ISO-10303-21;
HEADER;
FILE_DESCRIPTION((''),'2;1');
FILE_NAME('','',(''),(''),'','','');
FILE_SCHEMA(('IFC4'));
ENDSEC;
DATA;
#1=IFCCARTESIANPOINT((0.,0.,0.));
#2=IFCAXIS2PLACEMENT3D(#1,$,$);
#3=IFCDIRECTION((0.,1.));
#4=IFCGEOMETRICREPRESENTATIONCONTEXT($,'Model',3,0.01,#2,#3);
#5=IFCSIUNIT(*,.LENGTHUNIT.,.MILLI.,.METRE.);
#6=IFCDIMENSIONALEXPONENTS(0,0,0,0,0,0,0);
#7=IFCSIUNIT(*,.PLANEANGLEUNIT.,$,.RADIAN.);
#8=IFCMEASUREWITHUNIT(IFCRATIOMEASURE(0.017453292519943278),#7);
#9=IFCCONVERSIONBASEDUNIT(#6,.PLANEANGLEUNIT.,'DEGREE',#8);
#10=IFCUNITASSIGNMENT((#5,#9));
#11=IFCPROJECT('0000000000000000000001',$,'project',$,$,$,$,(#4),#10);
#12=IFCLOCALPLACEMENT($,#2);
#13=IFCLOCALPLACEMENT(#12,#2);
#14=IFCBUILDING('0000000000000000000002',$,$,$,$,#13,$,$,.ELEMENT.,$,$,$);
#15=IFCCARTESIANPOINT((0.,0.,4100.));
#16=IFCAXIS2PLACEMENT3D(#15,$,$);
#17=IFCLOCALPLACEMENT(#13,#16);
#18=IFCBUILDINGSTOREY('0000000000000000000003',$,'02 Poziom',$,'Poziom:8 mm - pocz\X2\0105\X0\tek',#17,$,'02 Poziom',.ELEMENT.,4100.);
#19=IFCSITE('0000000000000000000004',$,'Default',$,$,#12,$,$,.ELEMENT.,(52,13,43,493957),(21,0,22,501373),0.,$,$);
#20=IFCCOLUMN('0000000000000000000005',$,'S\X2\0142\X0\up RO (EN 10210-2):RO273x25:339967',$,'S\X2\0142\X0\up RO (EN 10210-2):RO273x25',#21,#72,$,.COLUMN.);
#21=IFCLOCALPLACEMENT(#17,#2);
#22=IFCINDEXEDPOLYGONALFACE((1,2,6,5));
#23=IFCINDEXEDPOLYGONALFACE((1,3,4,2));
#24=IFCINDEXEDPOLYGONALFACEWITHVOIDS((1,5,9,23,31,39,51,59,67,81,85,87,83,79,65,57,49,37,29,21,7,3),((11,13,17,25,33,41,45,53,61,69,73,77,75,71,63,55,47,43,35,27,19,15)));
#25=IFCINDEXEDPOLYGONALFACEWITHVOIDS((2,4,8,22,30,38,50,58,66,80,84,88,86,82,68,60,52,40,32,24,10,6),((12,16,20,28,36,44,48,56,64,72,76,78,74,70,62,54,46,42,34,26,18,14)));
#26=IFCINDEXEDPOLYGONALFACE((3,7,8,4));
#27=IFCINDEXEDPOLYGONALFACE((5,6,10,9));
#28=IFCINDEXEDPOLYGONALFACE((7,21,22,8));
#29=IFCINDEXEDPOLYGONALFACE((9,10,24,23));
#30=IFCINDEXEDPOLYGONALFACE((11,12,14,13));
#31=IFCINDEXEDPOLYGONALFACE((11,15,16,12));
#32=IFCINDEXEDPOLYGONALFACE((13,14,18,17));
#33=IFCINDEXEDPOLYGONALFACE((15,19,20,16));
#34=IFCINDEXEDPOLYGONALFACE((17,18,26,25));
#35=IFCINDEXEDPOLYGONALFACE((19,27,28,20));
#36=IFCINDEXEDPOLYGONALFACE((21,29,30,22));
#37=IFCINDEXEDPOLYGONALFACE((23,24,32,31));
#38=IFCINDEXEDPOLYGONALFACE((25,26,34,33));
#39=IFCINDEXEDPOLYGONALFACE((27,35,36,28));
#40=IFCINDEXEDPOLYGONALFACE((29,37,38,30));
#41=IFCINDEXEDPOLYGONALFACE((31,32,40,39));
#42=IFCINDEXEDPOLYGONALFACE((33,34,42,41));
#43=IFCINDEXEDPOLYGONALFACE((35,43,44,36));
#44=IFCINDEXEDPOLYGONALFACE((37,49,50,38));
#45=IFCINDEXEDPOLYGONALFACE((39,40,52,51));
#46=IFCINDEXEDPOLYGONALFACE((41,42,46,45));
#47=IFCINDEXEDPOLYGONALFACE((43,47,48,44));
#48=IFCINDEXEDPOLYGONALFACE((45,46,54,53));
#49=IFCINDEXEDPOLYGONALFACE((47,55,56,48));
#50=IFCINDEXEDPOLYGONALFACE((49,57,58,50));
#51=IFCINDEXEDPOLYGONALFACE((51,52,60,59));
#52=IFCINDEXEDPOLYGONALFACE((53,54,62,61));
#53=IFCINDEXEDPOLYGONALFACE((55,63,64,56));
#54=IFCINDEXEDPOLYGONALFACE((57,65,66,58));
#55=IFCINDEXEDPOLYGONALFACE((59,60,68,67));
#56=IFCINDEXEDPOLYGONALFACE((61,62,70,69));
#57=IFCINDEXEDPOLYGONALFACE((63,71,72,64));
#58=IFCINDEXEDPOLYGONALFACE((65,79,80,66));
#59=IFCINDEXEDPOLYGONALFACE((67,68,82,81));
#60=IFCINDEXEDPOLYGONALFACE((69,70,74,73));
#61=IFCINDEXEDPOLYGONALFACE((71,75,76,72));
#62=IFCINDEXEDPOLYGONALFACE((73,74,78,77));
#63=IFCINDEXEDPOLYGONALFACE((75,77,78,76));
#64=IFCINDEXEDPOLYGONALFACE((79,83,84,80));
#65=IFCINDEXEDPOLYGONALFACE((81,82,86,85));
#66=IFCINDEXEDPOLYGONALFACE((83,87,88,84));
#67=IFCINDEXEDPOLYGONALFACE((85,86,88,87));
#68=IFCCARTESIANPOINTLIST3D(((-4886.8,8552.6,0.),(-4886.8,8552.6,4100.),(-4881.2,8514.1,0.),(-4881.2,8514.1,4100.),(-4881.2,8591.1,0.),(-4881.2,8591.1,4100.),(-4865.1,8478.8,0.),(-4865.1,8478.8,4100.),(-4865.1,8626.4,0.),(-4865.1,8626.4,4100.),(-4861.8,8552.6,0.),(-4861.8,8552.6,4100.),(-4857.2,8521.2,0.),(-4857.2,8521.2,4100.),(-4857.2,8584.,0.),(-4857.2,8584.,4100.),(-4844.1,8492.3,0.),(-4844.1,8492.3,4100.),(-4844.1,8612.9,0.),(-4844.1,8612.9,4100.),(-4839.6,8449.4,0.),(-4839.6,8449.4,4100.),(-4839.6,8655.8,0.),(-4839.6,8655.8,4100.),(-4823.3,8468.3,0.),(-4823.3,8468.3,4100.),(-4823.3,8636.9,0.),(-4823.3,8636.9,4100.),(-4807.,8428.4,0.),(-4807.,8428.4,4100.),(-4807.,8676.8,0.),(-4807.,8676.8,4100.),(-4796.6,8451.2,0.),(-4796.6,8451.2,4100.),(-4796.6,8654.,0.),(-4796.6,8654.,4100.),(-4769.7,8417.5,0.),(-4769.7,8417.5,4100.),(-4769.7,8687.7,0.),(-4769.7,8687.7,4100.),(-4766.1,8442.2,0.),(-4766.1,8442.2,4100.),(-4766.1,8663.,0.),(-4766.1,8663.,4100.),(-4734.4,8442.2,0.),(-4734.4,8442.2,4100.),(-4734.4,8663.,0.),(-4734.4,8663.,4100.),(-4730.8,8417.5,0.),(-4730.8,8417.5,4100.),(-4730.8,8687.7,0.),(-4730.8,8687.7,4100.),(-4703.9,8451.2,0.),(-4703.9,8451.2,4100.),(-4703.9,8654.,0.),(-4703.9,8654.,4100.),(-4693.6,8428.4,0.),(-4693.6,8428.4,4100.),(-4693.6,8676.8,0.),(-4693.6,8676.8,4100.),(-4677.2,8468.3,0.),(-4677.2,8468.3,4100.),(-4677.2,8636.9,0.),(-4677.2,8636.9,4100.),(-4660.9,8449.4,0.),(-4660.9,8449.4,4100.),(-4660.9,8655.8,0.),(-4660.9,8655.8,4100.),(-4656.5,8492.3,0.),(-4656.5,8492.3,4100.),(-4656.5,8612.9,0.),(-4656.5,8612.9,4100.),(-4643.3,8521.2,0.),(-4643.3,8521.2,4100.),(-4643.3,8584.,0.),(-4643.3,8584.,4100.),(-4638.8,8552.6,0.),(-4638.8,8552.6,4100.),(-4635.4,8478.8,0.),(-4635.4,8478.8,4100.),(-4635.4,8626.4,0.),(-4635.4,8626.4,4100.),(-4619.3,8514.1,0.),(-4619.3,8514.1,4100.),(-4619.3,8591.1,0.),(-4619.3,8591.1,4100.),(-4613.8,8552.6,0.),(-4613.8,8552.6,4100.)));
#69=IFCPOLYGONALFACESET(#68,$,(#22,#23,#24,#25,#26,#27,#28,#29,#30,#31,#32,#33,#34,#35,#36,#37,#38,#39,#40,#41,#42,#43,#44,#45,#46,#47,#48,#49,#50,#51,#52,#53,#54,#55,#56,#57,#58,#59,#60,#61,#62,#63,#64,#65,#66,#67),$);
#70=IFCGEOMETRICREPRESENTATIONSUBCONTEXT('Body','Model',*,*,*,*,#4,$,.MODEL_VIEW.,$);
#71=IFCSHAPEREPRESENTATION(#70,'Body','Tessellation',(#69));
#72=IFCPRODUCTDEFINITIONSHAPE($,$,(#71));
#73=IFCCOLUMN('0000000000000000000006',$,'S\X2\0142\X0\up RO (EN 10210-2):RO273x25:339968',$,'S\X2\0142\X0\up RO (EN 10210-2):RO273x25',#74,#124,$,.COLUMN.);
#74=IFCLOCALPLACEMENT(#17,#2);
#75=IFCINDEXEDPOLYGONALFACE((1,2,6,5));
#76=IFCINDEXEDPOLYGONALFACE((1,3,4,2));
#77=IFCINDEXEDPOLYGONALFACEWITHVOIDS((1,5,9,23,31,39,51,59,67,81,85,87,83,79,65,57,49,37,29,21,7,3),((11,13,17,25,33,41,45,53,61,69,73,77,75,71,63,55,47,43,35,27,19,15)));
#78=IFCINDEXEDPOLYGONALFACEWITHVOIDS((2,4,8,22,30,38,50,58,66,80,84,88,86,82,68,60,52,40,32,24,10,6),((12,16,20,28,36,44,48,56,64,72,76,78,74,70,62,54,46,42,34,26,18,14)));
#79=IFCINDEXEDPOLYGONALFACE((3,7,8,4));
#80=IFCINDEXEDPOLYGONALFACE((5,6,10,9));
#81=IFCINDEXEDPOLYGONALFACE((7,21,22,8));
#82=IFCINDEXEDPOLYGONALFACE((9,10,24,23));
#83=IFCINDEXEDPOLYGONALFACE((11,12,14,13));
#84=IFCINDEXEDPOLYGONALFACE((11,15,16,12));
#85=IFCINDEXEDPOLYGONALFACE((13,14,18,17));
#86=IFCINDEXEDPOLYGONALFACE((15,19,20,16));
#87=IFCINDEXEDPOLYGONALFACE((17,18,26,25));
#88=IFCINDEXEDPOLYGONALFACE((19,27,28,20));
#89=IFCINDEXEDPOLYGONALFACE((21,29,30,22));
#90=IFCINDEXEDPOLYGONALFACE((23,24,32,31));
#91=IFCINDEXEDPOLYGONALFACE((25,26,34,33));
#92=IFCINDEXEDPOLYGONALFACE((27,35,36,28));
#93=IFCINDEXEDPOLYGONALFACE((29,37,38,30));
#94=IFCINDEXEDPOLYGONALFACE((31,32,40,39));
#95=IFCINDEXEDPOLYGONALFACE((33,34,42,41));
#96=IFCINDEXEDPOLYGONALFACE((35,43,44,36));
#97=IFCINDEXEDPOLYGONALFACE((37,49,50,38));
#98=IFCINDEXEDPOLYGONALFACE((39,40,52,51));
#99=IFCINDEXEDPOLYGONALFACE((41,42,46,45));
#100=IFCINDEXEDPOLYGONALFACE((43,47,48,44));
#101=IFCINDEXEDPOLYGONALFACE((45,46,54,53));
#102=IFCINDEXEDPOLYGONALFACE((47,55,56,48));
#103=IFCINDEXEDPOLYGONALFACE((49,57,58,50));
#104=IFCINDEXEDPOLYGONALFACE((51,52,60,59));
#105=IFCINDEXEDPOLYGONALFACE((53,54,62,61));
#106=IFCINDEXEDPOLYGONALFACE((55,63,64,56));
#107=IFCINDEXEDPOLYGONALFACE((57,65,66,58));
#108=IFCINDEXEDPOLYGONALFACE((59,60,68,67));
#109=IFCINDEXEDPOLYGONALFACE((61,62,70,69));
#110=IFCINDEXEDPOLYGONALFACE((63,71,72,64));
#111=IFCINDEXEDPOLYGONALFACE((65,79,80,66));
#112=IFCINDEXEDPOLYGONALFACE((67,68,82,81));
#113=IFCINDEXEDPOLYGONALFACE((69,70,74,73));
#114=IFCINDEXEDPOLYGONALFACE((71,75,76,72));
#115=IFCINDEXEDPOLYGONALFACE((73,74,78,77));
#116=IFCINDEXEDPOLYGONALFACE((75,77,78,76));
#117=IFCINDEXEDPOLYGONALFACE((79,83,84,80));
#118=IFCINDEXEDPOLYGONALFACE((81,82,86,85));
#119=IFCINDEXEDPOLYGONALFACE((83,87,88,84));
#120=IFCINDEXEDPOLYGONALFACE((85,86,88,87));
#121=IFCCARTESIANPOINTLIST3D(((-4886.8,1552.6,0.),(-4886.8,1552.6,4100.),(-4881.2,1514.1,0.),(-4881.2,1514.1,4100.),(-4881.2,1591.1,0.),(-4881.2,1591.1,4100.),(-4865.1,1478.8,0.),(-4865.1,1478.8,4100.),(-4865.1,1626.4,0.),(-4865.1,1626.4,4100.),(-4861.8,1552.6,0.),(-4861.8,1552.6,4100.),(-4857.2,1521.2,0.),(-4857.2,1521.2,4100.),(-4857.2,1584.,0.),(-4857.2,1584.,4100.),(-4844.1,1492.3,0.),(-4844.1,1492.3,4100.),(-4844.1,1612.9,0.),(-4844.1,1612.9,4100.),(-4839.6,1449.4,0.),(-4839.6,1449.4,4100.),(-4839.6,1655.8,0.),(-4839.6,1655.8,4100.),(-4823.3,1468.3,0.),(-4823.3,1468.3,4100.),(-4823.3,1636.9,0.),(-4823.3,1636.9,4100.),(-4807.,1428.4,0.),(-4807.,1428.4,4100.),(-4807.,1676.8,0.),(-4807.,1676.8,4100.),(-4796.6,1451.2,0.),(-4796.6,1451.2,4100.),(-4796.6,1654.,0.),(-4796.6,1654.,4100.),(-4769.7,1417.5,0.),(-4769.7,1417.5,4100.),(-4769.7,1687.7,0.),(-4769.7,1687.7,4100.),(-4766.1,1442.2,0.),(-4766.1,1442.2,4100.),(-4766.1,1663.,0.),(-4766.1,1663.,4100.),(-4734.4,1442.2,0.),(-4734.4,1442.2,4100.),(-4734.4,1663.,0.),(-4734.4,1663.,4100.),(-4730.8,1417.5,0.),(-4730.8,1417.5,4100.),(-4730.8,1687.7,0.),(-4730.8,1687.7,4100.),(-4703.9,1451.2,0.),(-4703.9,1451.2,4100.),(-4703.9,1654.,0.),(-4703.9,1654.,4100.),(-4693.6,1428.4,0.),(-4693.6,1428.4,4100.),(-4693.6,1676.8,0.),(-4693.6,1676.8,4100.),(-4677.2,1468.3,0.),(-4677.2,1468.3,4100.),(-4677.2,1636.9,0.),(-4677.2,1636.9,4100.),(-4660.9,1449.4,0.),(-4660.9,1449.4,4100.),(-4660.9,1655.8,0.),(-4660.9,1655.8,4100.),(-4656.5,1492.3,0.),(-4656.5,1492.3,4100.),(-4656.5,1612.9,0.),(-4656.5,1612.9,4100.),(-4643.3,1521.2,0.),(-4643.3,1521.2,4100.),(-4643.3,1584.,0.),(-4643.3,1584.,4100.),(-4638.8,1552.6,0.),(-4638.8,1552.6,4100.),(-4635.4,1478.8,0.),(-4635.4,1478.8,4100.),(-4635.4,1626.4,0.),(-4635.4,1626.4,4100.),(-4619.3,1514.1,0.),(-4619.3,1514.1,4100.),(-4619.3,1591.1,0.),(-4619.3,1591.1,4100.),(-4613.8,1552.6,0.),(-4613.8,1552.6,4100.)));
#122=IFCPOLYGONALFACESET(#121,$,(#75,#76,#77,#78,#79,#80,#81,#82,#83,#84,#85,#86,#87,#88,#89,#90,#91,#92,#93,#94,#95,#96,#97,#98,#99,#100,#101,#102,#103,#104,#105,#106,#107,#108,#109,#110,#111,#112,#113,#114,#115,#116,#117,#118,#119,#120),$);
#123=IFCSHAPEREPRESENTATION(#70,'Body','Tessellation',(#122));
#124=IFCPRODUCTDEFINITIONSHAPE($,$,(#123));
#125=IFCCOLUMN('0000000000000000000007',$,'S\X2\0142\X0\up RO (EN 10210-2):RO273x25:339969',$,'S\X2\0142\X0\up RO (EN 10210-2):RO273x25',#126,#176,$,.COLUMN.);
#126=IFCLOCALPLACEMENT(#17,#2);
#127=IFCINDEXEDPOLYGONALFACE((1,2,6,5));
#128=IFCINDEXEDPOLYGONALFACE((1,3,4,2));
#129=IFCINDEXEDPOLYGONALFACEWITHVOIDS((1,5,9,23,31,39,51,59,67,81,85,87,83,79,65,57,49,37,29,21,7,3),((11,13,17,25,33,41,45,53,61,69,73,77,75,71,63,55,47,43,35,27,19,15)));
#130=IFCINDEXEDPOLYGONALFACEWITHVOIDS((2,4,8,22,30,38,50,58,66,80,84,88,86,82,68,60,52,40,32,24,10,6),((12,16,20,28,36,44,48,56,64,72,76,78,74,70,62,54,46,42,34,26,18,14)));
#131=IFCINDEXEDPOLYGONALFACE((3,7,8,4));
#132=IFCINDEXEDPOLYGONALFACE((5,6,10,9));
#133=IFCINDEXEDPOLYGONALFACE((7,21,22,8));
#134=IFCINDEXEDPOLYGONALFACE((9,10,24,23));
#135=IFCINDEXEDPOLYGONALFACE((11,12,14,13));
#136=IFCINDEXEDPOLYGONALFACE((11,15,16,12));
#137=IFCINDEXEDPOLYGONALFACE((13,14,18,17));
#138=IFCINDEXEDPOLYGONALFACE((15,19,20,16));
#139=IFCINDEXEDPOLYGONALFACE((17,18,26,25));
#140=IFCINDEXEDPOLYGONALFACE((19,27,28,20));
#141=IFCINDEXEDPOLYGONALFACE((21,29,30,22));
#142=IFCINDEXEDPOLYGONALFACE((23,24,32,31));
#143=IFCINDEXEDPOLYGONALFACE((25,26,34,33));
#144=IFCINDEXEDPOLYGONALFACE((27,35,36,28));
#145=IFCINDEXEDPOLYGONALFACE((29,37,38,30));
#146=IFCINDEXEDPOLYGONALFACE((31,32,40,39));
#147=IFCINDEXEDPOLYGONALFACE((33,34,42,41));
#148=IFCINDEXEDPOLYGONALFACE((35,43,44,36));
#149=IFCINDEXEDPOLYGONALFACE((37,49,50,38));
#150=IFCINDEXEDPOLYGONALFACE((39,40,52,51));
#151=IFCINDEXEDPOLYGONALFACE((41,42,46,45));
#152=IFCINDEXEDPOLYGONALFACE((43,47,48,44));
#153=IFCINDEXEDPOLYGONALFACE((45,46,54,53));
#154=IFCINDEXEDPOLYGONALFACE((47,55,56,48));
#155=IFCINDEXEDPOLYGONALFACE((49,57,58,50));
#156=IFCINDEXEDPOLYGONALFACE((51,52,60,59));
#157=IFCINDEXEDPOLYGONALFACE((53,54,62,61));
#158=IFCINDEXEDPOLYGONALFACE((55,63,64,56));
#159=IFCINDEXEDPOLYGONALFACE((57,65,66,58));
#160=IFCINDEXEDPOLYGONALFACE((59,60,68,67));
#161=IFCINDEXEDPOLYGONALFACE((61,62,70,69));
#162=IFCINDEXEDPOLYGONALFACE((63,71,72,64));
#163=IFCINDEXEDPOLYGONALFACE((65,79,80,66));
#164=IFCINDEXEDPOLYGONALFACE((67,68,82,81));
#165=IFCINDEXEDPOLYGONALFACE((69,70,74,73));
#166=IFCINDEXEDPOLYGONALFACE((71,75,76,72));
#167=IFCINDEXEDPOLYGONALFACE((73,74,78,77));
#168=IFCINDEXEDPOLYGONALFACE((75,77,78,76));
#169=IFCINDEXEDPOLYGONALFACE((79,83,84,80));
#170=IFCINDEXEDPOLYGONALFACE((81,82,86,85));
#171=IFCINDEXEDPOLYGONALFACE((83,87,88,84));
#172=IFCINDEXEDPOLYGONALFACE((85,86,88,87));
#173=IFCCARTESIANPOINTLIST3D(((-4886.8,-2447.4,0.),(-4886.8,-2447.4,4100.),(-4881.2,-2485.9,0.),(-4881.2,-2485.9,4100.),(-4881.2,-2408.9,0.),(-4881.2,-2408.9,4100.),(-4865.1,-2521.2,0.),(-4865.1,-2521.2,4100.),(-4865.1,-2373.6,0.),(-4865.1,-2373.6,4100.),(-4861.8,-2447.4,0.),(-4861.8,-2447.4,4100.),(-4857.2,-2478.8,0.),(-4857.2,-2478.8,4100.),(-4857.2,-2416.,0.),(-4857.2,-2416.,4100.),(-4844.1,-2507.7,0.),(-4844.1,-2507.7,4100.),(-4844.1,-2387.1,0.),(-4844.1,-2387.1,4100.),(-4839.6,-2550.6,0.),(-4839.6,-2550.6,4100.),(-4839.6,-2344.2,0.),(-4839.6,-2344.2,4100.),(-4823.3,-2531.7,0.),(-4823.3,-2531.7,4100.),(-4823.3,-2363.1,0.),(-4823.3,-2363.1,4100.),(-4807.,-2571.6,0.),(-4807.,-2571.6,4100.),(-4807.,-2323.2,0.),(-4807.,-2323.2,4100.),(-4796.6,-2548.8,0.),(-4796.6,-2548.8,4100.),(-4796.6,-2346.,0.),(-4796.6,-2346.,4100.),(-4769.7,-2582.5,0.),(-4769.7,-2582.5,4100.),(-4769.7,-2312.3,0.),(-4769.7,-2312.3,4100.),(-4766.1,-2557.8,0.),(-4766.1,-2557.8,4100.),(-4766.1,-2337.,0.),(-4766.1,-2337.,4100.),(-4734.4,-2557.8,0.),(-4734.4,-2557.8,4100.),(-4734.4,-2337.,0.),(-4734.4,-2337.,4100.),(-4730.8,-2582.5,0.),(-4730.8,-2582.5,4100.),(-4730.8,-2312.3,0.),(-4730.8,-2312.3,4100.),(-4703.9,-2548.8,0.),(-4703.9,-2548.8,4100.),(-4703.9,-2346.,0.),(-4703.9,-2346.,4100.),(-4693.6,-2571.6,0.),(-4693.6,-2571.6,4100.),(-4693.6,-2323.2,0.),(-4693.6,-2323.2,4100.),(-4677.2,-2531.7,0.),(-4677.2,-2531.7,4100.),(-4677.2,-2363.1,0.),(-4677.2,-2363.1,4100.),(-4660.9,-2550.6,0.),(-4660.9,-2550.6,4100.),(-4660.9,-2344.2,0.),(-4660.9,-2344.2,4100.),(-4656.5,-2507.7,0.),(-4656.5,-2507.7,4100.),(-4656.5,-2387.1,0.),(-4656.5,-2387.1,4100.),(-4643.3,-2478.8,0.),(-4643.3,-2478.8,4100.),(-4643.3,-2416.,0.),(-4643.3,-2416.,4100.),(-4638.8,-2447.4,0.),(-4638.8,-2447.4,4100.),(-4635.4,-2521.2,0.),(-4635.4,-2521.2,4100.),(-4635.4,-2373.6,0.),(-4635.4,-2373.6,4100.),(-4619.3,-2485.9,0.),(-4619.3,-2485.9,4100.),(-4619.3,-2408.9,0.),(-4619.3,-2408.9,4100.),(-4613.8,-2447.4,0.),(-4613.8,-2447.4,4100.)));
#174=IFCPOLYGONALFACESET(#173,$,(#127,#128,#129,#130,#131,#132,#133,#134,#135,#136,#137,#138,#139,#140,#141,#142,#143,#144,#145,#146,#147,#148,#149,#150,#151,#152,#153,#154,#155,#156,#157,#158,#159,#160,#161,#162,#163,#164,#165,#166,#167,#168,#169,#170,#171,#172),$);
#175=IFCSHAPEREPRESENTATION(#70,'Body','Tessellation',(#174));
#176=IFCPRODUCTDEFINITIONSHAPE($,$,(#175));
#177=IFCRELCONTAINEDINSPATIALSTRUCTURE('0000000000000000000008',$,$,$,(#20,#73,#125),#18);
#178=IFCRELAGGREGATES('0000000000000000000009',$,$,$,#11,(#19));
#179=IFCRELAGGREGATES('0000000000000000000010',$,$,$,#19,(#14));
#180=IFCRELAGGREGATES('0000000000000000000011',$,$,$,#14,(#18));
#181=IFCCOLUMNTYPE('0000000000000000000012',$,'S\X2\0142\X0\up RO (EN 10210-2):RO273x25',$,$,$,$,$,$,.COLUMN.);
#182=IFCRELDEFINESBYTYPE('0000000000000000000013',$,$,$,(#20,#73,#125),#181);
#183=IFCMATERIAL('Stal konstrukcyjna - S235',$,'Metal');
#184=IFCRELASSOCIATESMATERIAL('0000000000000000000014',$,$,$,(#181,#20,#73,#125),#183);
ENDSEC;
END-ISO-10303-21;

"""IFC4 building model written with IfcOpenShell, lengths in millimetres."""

from ifc_helpers import new_model, entity, si_unit, converted_unit, direction, frame, origin, place, context, subcontext, project, spatial, arc, indexed_curve, outline, extrude, source, transform, mapped, material, type_object, type_shapes, element, save


model = new_model("IFC4")

# Units and contexts
model_context = context("Model", 3, precision=0.01, world=origin(), true_north=direction((0.0, 1.0)))
body_context = subcontext(model_context, "Body", "Model", "MODEL_VIEW")
ifc_project = project(units=[si_unit("LENGTHUNIT", "METRE", prefix="MILLI"), converted_unit("PLANEANGLEUNIT", "DEGREE", entity("IfcRatioMeasure", 0.017453292519943278), si_unit("PLANEANGLEUNIT", "RADIAN"), dimensions=[0, 0, 0, 0, 0, 0, 0])], contexts=[model_context])

# Site, building, storey
site_placement = place(None, origin())
site = spatial("IfcSite", under=ifc_project, at=site_placement, Name="Default", CompositionType="ELEMENT", RefLatitude=(52, 13, 43, 493957), RefLongitude=(21, 0, 22, 501373), RefElevation=0.0)
building_placement = place(site_placement, origin())
building = spatial("IfcBuilding", under=site, at=building_placement, CompositionType="ELEMENT")
storey_placement = place(building_placement, frame((0.0, 0.0, 4100.0)))
storey = spatial("IfcBuildingStorey", under=building, at=storey_placement, Name="02 Poziom", ObjectType="Poziom:8 mm - początek", LongName="02 Poziom", CompositionType="ELEMENT", Elevation=4100.0)

# Columns
ifc_material_1 = material(Name="Stal konstrukcyjna - S235", Category="Metal")
column_type = type_object("IfcColumnType", Name="Słup RO (EN 10210-2):RO273x25", PredefinedType="COLUMN", material=ifc_material_1)
shared_shape_1 = source(origin(), body_context, "Body", "SweptSolid", [
    extrude(outline(indexed_curve([(-136.5, 0.0), (0.0, -136.5), (136.5, 0.0), (0.0, 136.5)], segments=[arc(1, 2, 3), arc(3, 4, 1)], self_intersect=False), holes=[indexed_curve([(-111.5, 0.0), (0.0, 111.5), (111.5, 0.0), (0.0, -111.5)], segments=[arc(1, 2, 3), arc(3, 4, 1)], self_intersect=False)]), frame((0.0, 0.0, 4100.0)), (0.0, 0.0, 1.0), 4100.0),
])
type_shapes(column_type, [shared_shape_1])
for number, where, name in (
    (1, (-4750.3, 8552.6, -4100.0), "Słup RO (EN 10210-2):RO273x25:339967"),
    (2, (-4750.3, 1552.6, -4100.0), "Słup RO (EN 10210-2):RO273x25:339968"),
    (3, (-4750.3, -2447.4, -4100.0), "Słup RO (EN 10210-2):RO273x25:339969"),
):
    element("IfcColumn", number, at=place(storey_placement, frame(where)), inside=storey, type_object=column_type, material=ifc_material_1, Name=name, ObjectType="Słup RO (EN 10210-2):RO273x25", PredefinedType="COLUMN", context=body_context, shape_type="MappedRepresentation", body=[
        mapped(shared_shape_1, transform((0.0, 0.0, 0.0), scale=1.0)),
    ])

save(model, "model.ifc")
